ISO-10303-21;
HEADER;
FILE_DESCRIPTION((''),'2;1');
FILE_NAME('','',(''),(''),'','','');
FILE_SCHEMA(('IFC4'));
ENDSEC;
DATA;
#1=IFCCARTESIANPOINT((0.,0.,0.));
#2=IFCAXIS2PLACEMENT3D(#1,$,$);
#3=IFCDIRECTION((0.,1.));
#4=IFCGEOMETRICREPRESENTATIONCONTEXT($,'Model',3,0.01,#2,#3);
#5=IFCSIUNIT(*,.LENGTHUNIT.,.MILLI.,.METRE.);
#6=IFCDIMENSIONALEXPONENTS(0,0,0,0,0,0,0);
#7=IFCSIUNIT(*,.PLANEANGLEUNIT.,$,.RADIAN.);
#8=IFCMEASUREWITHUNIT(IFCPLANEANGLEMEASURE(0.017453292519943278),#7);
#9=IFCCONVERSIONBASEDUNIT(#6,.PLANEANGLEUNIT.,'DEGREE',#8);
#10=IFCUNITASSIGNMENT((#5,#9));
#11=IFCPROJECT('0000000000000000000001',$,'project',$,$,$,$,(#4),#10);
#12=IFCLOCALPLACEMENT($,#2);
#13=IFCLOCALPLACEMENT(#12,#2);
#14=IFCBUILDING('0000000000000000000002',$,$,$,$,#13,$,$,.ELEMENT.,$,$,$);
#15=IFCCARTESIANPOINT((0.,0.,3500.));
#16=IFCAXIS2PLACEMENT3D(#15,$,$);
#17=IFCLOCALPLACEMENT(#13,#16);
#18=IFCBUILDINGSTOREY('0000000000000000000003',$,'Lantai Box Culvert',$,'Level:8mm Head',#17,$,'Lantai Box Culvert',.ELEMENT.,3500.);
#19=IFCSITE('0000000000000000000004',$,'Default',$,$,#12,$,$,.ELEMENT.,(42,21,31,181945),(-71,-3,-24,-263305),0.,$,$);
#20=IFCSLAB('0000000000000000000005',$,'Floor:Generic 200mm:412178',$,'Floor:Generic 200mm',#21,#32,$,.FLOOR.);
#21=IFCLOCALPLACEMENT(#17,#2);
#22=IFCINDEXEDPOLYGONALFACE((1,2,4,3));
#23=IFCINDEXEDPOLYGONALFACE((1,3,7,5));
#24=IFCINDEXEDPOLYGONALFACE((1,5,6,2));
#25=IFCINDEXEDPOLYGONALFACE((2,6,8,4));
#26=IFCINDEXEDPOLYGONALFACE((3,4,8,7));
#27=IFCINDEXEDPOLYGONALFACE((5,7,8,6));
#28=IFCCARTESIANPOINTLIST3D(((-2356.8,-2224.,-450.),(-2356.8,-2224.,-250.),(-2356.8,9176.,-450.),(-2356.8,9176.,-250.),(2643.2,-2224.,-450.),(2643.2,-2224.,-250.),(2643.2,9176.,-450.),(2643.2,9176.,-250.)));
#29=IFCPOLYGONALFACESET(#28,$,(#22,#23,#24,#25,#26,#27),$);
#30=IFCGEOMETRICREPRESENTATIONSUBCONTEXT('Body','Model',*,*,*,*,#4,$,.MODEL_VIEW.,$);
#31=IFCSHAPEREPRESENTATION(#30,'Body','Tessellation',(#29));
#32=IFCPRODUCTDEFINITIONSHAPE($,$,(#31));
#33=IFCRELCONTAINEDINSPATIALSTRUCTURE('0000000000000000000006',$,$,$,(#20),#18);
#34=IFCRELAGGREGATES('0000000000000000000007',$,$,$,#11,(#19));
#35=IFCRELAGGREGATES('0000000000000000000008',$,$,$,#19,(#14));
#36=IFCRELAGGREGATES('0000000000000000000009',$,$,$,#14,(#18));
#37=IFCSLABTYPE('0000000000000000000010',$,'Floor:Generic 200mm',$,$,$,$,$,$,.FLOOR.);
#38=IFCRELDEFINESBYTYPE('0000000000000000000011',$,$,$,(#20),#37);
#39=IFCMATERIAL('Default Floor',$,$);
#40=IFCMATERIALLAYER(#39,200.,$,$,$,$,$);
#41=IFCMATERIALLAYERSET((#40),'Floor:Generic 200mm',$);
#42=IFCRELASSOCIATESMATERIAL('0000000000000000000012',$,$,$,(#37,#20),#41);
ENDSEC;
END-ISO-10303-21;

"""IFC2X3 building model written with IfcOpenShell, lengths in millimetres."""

from ifc_helpers import new_model, entity, si_unit, converted_unit, direction, frame, frame_2d, origin, place, context, subcontext, project, spatial, rectangle, extrude, material, layer, layer_set, layer_usage, type_object, element, save


model = new_model("IFC2X3")

# Units and contexts
model_context = context("Model", 3, precision=0.01, world=origin(), true_north=direction((0.0, 1.0)))
body_context = subcontext(model_context, "Body", "Model", "MODEL_VIEW")
ifc_project = project(units=[si_unit("LENGTHUNIT", "METRE", prefix="MILLI"), converted_unit("PLANEANGLEUNIT", "DEGREE", entity("IfcPlaneAngleMeasure", 0.017453292519943278), si_unit("PLANEANGLEUNIT", "RADIAN"), dimensions=[0, 0, 0, 0, 0, 0, 0])], contexts=[model_context])

# Site, building, storey
site_placement = place(None, origin())
site = spatial("IfcSite", under=ifc_project, at=site_placement, Name="Default", CompositionType="ELEMENT", RefLatitude=(42, 21, 31, 181945), RefLongitude=(-71, -3, -24, -263305), RefElevation=0.0)
building_placement = place(site_placement, origin())
building = spatial("IfcBuilding", under=site, at=building_placement, CompositionType="ELEMENT")
storey_placement = place(building_placement, frame((0.0, 0.0, 3500.0)))
storey = spatial("IfcBuildingStorey", under=building, at=storey_placement, Name="Lantai Box Culvert", ObjectType="Level:8mm Head", LongName="Lantai Box Culvert", CompositionType="ELEMENT", Elevation=3500.0)

# Slab
ifc_material = material(Name="Default Floor")
ifc_layer = layer(ifc_material, 200.0)
ifc_layer_set = layer_set([ifc_layer], Name="Floor:Generic 200mm")
ifc_layer_usage = layer_usage(ifc_layer_set, "AXIS3", "POSITIVE", 0.0)
slab_type = type_object("IfcSlabType", Name="Floor:Generic 200mm", PredefinedType="FLOOR", material=ifc_layer_set)
slab_placement = place(storey_placement, origin())
element("IfcSlab", 1, at=slab_placement, inside=storey, type_object=slab_type, material=ifc_layer_usage, Name="Floor:Generic 200mm:412178", ObjectType="Floor:Generic 200mm", PredefinedType="FLOOR", context=body_context, shape_type="SweptSolid", body=[
    extrude(rectangle(XDim=11400.0, YDim=5000.0, at=frame_2d((0.0, 0.0), x_axis=(1.0, 0.0))), frame((143.2, 3476.0, -250.0), z_axis=(0.0, 0.0, -1.0), x_axis=(0.0, 1.0, 0.0)), (0.0, 0.0, 1.0), 200.0),
])

save(model, "model.ifc")
